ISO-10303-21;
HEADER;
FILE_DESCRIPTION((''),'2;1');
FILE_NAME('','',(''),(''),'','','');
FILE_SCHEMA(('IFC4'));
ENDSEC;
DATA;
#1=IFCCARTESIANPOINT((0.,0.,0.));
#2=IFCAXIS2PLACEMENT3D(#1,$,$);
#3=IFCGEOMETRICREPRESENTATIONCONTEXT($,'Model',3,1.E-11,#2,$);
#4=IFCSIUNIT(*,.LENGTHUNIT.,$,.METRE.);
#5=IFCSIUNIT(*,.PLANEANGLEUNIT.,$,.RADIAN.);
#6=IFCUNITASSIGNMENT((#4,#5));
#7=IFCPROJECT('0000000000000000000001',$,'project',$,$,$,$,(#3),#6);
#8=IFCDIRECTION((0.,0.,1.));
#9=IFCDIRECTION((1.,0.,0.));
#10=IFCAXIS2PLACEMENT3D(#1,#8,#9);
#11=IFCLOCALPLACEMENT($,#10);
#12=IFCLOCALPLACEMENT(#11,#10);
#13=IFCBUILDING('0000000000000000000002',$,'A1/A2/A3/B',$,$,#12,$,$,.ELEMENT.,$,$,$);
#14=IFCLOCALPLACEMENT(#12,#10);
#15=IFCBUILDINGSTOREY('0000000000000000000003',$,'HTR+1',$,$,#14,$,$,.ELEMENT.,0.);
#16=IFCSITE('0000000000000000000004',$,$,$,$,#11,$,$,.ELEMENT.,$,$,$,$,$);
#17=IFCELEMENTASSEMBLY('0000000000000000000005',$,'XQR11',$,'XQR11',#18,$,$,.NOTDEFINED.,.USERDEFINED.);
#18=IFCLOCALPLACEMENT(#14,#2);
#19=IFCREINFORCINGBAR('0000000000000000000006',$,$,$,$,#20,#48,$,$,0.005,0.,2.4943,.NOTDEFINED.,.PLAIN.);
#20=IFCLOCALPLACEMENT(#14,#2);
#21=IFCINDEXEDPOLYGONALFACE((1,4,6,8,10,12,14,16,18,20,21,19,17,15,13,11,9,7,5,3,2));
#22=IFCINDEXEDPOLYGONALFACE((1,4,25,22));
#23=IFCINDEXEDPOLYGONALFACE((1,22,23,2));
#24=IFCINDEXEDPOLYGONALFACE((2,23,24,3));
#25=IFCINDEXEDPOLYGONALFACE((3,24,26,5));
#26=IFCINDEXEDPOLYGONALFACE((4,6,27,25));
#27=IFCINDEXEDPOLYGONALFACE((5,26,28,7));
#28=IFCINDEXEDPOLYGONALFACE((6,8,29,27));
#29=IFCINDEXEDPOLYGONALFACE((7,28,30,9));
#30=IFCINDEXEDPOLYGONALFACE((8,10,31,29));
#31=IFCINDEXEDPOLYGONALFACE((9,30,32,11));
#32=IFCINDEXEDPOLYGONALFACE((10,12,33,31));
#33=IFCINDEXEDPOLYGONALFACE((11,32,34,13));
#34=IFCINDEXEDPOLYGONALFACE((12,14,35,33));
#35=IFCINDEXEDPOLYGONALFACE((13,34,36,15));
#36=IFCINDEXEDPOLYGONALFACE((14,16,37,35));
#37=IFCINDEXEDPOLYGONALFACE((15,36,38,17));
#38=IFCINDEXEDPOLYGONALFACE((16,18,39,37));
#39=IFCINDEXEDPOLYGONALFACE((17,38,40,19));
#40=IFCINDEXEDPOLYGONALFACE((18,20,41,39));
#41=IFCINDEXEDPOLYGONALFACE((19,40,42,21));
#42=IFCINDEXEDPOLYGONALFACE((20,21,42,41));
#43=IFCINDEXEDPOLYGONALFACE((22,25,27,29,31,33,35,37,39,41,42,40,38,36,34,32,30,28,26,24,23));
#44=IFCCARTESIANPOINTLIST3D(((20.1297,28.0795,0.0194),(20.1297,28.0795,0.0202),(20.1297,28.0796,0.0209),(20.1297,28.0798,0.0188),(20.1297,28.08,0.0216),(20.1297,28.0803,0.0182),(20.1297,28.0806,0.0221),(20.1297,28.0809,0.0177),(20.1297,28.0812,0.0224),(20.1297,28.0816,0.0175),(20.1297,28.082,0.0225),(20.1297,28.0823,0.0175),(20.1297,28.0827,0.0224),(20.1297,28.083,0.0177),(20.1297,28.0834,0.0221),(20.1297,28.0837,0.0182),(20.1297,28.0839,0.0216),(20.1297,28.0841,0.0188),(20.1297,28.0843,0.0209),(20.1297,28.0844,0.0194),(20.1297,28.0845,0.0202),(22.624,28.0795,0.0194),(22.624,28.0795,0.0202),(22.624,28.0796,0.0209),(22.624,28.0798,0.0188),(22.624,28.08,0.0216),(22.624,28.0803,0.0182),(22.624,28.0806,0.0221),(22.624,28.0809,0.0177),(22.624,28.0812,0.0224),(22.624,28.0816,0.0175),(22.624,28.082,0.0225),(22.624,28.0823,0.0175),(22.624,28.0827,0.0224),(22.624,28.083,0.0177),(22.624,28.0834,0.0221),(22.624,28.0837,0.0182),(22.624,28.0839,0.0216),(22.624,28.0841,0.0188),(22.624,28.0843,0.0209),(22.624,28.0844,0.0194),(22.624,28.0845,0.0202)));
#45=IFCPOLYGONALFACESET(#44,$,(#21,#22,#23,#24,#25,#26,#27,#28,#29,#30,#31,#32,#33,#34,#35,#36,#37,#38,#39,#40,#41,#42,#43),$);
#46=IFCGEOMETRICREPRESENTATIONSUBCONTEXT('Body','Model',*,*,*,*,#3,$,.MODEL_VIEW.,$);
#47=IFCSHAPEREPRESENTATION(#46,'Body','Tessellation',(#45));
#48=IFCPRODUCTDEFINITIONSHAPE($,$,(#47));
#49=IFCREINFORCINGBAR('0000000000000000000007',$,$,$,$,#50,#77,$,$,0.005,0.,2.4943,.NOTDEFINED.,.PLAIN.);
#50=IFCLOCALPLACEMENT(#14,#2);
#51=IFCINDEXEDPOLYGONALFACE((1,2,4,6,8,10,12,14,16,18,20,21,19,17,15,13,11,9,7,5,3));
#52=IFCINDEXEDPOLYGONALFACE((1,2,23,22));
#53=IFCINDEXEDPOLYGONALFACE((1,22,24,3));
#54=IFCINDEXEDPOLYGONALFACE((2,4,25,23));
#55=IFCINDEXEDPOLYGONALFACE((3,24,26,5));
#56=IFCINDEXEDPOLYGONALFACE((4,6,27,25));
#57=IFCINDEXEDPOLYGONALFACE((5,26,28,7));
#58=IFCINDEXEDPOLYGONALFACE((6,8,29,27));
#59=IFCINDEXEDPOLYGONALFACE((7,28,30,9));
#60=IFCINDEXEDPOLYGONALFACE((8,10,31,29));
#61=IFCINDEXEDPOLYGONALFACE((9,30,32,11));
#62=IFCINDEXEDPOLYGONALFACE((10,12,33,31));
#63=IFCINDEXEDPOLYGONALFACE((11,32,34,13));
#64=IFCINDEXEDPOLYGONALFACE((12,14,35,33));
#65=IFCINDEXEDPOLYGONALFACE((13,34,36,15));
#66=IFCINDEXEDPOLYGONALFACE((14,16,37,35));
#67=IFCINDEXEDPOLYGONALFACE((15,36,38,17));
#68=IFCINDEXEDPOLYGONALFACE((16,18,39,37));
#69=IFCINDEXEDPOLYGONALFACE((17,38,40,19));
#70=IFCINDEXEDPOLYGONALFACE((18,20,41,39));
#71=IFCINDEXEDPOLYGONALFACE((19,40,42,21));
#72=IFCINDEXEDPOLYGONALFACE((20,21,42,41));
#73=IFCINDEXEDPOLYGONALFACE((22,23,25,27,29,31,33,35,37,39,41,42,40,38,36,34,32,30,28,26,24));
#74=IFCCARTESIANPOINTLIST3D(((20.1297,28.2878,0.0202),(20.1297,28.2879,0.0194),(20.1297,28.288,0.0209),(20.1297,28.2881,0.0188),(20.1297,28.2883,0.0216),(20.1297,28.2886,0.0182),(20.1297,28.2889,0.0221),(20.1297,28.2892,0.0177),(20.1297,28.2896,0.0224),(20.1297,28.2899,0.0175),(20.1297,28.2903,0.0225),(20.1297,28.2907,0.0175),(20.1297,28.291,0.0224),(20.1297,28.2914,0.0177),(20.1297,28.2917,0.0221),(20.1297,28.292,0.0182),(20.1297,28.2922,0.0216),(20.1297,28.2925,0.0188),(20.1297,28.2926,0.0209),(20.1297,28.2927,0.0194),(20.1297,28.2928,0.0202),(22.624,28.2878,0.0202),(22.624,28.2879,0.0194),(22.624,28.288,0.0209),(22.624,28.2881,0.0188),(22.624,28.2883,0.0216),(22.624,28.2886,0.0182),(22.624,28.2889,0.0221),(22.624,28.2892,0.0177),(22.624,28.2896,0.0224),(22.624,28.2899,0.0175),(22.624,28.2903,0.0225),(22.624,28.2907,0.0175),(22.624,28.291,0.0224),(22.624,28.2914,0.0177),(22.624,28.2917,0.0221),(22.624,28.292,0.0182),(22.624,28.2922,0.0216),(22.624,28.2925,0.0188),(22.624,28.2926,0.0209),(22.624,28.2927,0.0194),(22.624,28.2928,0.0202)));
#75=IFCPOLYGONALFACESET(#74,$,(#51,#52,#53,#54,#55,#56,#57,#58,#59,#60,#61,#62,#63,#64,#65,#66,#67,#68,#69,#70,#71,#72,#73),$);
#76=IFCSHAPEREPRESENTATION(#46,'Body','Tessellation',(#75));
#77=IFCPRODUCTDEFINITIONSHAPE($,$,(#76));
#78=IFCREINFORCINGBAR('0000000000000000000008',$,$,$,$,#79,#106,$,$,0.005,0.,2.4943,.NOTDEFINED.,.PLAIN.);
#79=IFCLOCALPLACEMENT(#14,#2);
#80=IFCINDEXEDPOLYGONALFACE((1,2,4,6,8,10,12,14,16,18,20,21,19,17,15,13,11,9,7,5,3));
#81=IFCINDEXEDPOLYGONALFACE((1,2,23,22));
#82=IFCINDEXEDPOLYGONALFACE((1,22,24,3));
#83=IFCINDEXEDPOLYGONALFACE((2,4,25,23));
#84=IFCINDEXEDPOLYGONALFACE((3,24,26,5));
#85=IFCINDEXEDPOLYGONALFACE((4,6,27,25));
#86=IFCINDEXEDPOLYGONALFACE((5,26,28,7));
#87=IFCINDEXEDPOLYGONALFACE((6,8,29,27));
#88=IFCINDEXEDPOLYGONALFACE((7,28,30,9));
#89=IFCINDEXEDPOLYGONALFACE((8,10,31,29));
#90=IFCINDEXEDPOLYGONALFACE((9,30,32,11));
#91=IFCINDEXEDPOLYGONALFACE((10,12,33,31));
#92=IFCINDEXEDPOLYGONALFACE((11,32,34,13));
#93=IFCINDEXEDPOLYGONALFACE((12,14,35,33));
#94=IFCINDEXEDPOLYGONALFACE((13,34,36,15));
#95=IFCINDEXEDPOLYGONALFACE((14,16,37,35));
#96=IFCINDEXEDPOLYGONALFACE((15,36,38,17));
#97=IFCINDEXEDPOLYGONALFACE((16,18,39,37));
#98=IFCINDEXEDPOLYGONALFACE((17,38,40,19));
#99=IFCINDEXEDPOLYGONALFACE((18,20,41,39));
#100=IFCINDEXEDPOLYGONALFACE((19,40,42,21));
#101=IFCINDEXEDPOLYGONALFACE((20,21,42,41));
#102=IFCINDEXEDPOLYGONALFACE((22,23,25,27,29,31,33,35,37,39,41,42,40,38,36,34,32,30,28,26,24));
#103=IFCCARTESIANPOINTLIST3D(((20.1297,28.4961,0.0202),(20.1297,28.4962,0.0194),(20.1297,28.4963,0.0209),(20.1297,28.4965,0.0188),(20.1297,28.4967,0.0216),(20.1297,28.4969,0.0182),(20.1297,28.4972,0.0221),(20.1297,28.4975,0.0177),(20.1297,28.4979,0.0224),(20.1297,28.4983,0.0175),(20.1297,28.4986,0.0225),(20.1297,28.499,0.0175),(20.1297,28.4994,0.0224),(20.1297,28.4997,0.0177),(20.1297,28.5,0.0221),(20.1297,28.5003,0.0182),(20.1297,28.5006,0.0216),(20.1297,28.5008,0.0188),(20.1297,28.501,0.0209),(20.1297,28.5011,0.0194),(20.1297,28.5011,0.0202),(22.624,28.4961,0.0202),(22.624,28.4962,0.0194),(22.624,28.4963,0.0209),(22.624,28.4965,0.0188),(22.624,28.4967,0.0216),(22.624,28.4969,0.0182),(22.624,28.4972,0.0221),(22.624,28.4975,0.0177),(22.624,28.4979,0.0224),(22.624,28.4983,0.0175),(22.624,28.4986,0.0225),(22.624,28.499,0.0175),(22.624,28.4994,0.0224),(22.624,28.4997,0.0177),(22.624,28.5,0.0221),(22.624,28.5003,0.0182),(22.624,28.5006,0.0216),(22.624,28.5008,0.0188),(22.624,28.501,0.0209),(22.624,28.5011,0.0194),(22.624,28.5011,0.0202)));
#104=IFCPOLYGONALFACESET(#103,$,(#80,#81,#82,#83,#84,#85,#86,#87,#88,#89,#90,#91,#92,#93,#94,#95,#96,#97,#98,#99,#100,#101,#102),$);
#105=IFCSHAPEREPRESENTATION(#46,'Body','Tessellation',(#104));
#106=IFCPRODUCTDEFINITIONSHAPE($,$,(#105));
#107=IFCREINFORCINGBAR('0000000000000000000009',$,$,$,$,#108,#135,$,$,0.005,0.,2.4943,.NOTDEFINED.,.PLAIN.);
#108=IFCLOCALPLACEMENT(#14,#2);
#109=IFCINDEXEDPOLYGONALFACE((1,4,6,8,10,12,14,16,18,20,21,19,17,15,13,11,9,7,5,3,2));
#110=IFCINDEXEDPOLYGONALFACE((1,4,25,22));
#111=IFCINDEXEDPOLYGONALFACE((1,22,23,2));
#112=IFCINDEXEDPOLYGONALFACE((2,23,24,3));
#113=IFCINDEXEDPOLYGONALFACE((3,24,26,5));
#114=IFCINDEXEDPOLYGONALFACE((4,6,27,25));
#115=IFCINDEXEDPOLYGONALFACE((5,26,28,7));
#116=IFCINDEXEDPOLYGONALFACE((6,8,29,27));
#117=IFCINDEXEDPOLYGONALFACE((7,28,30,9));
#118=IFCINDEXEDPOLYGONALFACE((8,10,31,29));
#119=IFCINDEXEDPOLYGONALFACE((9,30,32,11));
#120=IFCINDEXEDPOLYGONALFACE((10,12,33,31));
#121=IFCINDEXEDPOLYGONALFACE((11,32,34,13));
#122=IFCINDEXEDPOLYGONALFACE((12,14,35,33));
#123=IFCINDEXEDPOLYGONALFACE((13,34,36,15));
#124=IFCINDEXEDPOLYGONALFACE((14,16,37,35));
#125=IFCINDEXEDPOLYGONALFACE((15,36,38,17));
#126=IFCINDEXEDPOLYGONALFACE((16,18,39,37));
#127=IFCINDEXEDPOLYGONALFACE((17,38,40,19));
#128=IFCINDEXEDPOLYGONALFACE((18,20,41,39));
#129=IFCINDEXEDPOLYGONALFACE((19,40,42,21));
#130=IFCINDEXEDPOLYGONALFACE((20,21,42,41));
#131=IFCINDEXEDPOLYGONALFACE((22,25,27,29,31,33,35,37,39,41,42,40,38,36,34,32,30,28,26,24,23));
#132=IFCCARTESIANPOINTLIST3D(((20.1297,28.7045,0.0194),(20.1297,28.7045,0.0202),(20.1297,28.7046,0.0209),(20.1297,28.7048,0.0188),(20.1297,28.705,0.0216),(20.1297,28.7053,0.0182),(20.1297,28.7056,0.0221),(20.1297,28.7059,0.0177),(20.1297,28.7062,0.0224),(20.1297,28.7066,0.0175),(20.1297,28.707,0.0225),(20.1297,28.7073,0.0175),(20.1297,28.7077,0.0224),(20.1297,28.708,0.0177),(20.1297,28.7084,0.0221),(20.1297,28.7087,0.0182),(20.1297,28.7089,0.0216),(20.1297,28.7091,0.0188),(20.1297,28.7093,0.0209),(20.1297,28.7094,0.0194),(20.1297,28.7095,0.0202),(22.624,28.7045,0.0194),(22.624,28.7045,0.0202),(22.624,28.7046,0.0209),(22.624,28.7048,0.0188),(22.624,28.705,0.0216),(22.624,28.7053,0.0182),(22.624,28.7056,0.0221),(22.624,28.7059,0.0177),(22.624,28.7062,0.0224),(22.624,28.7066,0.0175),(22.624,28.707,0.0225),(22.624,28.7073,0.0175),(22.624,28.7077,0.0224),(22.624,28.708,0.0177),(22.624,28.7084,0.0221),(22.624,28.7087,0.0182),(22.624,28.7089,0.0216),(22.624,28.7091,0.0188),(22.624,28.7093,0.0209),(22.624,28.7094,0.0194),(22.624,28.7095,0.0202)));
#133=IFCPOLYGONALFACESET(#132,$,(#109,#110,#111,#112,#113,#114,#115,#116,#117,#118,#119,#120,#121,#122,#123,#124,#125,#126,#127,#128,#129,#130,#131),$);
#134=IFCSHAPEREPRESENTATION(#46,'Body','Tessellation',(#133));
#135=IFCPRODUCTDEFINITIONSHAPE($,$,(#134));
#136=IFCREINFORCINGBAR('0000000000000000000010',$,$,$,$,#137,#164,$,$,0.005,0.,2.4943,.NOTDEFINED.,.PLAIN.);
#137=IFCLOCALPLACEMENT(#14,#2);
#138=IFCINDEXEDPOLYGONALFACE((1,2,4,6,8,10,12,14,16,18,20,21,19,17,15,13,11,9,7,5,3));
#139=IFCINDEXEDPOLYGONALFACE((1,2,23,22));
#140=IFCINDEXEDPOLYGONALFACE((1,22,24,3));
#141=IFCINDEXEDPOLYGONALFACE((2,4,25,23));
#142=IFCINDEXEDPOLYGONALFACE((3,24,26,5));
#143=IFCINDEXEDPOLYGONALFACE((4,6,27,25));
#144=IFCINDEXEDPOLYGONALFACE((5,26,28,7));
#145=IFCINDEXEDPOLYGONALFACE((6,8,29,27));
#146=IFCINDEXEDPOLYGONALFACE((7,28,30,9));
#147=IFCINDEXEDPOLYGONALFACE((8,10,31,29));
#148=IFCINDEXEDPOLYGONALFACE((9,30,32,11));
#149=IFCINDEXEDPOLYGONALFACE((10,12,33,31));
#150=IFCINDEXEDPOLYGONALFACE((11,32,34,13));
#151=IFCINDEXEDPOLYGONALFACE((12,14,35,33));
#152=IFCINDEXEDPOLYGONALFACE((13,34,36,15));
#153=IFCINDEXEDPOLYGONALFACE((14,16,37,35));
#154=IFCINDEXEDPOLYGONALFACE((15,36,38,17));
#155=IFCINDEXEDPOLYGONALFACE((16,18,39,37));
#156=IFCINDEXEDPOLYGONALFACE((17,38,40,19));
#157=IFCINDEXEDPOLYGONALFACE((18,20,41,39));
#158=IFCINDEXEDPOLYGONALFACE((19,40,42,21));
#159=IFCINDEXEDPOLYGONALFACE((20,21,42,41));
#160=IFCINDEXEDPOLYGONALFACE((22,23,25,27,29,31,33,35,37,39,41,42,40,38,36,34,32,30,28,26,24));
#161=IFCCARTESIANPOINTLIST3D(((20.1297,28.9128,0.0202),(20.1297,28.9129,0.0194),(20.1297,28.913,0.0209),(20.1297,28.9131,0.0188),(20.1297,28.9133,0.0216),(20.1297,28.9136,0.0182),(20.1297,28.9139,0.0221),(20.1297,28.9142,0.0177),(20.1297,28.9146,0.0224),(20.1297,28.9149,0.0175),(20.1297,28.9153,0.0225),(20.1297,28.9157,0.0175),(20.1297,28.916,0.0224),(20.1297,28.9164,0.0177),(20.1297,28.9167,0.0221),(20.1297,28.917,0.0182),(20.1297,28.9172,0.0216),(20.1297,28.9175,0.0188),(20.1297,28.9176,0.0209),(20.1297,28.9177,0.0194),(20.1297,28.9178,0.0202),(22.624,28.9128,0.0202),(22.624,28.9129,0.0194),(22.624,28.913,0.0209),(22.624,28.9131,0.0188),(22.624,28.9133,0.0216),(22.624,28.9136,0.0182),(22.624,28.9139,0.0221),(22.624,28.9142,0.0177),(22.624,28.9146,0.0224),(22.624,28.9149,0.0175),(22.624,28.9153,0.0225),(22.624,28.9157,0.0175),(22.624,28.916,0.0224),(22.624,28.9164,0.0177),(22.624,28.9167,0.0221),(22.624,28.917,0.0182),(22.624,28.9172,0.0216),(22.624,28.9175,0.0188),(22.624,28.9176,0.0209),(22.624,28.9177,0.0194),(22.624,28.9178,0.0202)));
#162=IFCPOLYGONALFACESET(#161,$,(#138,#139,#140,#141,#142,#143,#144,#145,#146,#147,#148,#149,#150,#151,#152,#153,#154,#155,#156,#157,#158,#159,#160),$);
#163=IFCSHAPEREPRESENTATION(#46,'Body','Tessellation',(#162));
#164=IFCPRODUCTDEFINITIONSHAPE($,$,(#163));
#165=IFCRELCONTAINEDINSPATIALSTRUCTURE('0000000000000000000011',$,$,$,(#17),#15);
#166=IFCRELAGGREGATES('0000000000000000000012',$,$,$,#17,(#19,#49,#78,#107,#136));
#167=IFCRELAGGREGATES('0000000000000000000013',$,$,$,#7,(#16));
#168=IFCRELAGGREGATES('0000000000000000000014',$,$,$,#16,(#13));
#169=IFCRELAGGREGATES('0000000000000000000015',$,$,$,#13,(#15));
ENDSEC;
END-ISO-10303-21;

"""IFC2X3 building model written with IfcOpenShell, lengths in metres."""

from ifc_helpers import new_model, entity, si_unit, origin, origin_with_axes, place, context, subcontext, project, spatial, shape, element, aggregate, save


model = new_model("IFC2X3")

# Units and contexts
model_context = context("Model", 3, precision=1e-11, world=origin())
body_context = subcontext(model_context, "Body", "Model", "MODEL_VIEW")
ifc_project = project(units=[si_unit("LENGTHUNIT", "METRE"), si_unit("PLANEANGLEUNIT", "RADIAN")], contexts=[model_context])

# Site, building, storey
site_placement = place(None, origin_with_axes())
site = spatial("IfcSite", under=ifc_project, at=site_placement, CompositionType="ELEMENT")
building_placement = place(site_placement, origin_with_axes())
building = spatial("IfcBuilding", under=site, at=building_placement, Name="A1/A2/A3/B", CompositionType="ELEMENT")
storey_placement = place(building_placement, origin_with_axes())
storey = spatial("IfcBuildingStorey", under=building, at=storey_placement, Name="HTR+1", CompositionType="ELEMENT", Elevation=0.0)

# Element assembly, reinforcing bars
assembly_1_placement = place(storey_placement, origin_with_axes())
assembly_1 = element("IfcElementAssembly", 1, at=assembly_1_placement, inside=storey, Name="XQR11", ObjectType="XQR11", AssemblyPlace="NOTDEFINED", PredefinedType="USERDEFINED")
reinforcing_bar_1_placement = place(assembly_1_placement, origin_with_axes())
reinforcing_bar_1 = element("IfcReinforcingBar", 2, at=reinforcing_bar_1_placement, BarLength=2.4943, BarRole="NOTDEFINED", BarSurface="PLAIN", CrossSectionArea=0.0, NominalDiameter=0.005, shapes=[
    shape(body_context, "Body", "AdvancedSweptSolid", [entity("IfcSweptDiskSolid", entity("IfcPolyline", [entity("IfcCartesianPoint", [20.1297, 28.082, 0.02]), entity("IfcCartesianPoint", [22.624, 28.082, 0.02])]), 0.0025, None, 0.0, 2.4943)]),
    shape(body_context, "Body", "AdvancedSweptSolid", [entity("IfcSweptDiskSolid", entity("IfcPolyline", [entity("IfcCartesianPoint", [20.1297, 28.082, 0.02]), entity("IfcCartesianPoint", [22.624, 28.082, 0.02])]), 0.0025, None, 0.0, 2.4943)]),
])
reinforcing_bar_2_placement = place(assembly_1_placement, origin_with_axes())
reinforcing_bar_2 = element("IfcReinforcingBar", 3, at=reinforcing_bar_2_placement, BarLength=2.4943, BarRole="NOTDEFINED", BarSurface="PLAIN", CrossSectionArea=0.0, NominalDiameter=0.005, shapes=[
    shape(body_context, "Body", "AdvancedSweptSolid", [entity("IfcSweptDiskSolid", entity("IfcPolyline", [entity("IfcCartesianPoint", [20.1297, 28.2903, 0.02]), entity("IfcCartesianPoint", [22.624, 28.2903, 0.02])]), 0.0025, None, 0.0, 2.4943)]),
    shape(body_context, "Body", "AdvancedSweptSolid", [entity("IfcSweptDiskSolid", entity("IfcPolyline", [entity("IfcCartesianPoint", [20.1297, 28.2903, 0.02]), entity("IfcCartesianPoint", [22.624, 28.2903, 0.02])]), 0.0025, None, 0.0, 2.4943)]),
])
reinforcing_bar_3_placement = place(assembly_1_placement, origin_with_axes())
reinforcing_bar_3 = element("IfcReinforcingBar", 4, at=reinforcing_bar_3_placement, BarLength=2.4943, BarRole="NOTDEFINED", BarSurface="PLAIN", CrossSectionArea=0.0, NominalDiameter=0.005, shapes=[
    shape(body_context, "Body", "AdvancedSweptSolid", [entity("IfcSweptDiskSolid", entity("IfcPolyline", [entity("IfcCartesianPoint", [20.1297, 28.4986, 0.02]), entity("IfcCartesianPoint", [22.624, 28.4986, 0.02])]), 0.0025, None, 0.0, 2.4943)]),
    shape(body_context, "Body", "AdvancedSweptSolid", [entity("IfcSweptDiskSolid", entity("IfcPolyline", [entity("IfcCartesianPoint", [20.1297, 28.4986, 0.02]), entity("IfcCartesianPoint", [22.624, 28.4986, 0.02])]), 0.0025, None, 0.0, 2.4943)]),
])
reinforcing_bar_4_placement = place(assembly_1_placement, origin_with_axes())
reinforcing_bar_4 = element("IfcReinforcingBar", 5, at=reinforcing_bar_4_placement, BarLength=2.4943, BarRole="NOTDEFINED", BarSurface="PLAIN", CrossSectionArea=0.0, NominalDiameter=0.005, shapes=[
    shape(body_context, "Body", "AdvancedSweptSolid", [entity("IfcSweptDiskSolid", entity("IfcPolyline", [entity("IfcCartesianPoint", [20.1297, 28.707, 0.02]), entity("IfcCartesianPoint", [22.624, 28.707, 0.02])]), 0.0025, None, 0.0, 2.4943)]),
    shape(body_context, "Body", "AdvancedSweptSolid", [entity("IfcSweptDiskSolid", entity("IfcPolyline", [entity("IfcCartesianPoint", [20.1297, 28.707, 0.02]), entity("IfcCartesianPoint", [22.624, 28.707, 0.02])]), 0.0025, None, 0.0, 2.4943)]),
])
reinforcing_bar_5_placement = place(assembly_1_placement, origin_with_axes())
reinforcing_bar_5 = element("IfcReinforcingBar", 6, at=reinforcing_bar_5_placement, BarLength=2.4943, BarRole="NOTDEFINED", BarSurface="PLAIN", CrossSectionArea=0.0, NominalDiameter=0.005, shapes=[
    shape(body_context, "Body", "AdvancedSweptSolid", [entity("IfcSweptDiskSolid", entity("IfcPolyline", [entity("IfcCartesianPoint", [20.1297, 28.9153, 0.02]), entity("IfcCartesianPoint", [22.624, 28.9153, 0.02])]), 0.0025, None, 0.0, 2.4943)]),
    shape(body_context, "Body", "AdvancedSweptSolid", [entity("IfcSweptDiskSolid", entity("IfcPolyline", [entity("IfcCartesianPoint", [20.1297, 28.9153, 0.02]), entity("IfcCartesianPoint", [22.624, 28.9153, 0.02])]), 0.0025, None, 0.0, 2.4943)]),
])
aggregate(assembly_1, [reinforcing_bar_1, reinforcing_bar_2, reinforcing_bar_3, reinforcing_bar_4, reinforcing_bar_5])

save(model, "model.ifc")
